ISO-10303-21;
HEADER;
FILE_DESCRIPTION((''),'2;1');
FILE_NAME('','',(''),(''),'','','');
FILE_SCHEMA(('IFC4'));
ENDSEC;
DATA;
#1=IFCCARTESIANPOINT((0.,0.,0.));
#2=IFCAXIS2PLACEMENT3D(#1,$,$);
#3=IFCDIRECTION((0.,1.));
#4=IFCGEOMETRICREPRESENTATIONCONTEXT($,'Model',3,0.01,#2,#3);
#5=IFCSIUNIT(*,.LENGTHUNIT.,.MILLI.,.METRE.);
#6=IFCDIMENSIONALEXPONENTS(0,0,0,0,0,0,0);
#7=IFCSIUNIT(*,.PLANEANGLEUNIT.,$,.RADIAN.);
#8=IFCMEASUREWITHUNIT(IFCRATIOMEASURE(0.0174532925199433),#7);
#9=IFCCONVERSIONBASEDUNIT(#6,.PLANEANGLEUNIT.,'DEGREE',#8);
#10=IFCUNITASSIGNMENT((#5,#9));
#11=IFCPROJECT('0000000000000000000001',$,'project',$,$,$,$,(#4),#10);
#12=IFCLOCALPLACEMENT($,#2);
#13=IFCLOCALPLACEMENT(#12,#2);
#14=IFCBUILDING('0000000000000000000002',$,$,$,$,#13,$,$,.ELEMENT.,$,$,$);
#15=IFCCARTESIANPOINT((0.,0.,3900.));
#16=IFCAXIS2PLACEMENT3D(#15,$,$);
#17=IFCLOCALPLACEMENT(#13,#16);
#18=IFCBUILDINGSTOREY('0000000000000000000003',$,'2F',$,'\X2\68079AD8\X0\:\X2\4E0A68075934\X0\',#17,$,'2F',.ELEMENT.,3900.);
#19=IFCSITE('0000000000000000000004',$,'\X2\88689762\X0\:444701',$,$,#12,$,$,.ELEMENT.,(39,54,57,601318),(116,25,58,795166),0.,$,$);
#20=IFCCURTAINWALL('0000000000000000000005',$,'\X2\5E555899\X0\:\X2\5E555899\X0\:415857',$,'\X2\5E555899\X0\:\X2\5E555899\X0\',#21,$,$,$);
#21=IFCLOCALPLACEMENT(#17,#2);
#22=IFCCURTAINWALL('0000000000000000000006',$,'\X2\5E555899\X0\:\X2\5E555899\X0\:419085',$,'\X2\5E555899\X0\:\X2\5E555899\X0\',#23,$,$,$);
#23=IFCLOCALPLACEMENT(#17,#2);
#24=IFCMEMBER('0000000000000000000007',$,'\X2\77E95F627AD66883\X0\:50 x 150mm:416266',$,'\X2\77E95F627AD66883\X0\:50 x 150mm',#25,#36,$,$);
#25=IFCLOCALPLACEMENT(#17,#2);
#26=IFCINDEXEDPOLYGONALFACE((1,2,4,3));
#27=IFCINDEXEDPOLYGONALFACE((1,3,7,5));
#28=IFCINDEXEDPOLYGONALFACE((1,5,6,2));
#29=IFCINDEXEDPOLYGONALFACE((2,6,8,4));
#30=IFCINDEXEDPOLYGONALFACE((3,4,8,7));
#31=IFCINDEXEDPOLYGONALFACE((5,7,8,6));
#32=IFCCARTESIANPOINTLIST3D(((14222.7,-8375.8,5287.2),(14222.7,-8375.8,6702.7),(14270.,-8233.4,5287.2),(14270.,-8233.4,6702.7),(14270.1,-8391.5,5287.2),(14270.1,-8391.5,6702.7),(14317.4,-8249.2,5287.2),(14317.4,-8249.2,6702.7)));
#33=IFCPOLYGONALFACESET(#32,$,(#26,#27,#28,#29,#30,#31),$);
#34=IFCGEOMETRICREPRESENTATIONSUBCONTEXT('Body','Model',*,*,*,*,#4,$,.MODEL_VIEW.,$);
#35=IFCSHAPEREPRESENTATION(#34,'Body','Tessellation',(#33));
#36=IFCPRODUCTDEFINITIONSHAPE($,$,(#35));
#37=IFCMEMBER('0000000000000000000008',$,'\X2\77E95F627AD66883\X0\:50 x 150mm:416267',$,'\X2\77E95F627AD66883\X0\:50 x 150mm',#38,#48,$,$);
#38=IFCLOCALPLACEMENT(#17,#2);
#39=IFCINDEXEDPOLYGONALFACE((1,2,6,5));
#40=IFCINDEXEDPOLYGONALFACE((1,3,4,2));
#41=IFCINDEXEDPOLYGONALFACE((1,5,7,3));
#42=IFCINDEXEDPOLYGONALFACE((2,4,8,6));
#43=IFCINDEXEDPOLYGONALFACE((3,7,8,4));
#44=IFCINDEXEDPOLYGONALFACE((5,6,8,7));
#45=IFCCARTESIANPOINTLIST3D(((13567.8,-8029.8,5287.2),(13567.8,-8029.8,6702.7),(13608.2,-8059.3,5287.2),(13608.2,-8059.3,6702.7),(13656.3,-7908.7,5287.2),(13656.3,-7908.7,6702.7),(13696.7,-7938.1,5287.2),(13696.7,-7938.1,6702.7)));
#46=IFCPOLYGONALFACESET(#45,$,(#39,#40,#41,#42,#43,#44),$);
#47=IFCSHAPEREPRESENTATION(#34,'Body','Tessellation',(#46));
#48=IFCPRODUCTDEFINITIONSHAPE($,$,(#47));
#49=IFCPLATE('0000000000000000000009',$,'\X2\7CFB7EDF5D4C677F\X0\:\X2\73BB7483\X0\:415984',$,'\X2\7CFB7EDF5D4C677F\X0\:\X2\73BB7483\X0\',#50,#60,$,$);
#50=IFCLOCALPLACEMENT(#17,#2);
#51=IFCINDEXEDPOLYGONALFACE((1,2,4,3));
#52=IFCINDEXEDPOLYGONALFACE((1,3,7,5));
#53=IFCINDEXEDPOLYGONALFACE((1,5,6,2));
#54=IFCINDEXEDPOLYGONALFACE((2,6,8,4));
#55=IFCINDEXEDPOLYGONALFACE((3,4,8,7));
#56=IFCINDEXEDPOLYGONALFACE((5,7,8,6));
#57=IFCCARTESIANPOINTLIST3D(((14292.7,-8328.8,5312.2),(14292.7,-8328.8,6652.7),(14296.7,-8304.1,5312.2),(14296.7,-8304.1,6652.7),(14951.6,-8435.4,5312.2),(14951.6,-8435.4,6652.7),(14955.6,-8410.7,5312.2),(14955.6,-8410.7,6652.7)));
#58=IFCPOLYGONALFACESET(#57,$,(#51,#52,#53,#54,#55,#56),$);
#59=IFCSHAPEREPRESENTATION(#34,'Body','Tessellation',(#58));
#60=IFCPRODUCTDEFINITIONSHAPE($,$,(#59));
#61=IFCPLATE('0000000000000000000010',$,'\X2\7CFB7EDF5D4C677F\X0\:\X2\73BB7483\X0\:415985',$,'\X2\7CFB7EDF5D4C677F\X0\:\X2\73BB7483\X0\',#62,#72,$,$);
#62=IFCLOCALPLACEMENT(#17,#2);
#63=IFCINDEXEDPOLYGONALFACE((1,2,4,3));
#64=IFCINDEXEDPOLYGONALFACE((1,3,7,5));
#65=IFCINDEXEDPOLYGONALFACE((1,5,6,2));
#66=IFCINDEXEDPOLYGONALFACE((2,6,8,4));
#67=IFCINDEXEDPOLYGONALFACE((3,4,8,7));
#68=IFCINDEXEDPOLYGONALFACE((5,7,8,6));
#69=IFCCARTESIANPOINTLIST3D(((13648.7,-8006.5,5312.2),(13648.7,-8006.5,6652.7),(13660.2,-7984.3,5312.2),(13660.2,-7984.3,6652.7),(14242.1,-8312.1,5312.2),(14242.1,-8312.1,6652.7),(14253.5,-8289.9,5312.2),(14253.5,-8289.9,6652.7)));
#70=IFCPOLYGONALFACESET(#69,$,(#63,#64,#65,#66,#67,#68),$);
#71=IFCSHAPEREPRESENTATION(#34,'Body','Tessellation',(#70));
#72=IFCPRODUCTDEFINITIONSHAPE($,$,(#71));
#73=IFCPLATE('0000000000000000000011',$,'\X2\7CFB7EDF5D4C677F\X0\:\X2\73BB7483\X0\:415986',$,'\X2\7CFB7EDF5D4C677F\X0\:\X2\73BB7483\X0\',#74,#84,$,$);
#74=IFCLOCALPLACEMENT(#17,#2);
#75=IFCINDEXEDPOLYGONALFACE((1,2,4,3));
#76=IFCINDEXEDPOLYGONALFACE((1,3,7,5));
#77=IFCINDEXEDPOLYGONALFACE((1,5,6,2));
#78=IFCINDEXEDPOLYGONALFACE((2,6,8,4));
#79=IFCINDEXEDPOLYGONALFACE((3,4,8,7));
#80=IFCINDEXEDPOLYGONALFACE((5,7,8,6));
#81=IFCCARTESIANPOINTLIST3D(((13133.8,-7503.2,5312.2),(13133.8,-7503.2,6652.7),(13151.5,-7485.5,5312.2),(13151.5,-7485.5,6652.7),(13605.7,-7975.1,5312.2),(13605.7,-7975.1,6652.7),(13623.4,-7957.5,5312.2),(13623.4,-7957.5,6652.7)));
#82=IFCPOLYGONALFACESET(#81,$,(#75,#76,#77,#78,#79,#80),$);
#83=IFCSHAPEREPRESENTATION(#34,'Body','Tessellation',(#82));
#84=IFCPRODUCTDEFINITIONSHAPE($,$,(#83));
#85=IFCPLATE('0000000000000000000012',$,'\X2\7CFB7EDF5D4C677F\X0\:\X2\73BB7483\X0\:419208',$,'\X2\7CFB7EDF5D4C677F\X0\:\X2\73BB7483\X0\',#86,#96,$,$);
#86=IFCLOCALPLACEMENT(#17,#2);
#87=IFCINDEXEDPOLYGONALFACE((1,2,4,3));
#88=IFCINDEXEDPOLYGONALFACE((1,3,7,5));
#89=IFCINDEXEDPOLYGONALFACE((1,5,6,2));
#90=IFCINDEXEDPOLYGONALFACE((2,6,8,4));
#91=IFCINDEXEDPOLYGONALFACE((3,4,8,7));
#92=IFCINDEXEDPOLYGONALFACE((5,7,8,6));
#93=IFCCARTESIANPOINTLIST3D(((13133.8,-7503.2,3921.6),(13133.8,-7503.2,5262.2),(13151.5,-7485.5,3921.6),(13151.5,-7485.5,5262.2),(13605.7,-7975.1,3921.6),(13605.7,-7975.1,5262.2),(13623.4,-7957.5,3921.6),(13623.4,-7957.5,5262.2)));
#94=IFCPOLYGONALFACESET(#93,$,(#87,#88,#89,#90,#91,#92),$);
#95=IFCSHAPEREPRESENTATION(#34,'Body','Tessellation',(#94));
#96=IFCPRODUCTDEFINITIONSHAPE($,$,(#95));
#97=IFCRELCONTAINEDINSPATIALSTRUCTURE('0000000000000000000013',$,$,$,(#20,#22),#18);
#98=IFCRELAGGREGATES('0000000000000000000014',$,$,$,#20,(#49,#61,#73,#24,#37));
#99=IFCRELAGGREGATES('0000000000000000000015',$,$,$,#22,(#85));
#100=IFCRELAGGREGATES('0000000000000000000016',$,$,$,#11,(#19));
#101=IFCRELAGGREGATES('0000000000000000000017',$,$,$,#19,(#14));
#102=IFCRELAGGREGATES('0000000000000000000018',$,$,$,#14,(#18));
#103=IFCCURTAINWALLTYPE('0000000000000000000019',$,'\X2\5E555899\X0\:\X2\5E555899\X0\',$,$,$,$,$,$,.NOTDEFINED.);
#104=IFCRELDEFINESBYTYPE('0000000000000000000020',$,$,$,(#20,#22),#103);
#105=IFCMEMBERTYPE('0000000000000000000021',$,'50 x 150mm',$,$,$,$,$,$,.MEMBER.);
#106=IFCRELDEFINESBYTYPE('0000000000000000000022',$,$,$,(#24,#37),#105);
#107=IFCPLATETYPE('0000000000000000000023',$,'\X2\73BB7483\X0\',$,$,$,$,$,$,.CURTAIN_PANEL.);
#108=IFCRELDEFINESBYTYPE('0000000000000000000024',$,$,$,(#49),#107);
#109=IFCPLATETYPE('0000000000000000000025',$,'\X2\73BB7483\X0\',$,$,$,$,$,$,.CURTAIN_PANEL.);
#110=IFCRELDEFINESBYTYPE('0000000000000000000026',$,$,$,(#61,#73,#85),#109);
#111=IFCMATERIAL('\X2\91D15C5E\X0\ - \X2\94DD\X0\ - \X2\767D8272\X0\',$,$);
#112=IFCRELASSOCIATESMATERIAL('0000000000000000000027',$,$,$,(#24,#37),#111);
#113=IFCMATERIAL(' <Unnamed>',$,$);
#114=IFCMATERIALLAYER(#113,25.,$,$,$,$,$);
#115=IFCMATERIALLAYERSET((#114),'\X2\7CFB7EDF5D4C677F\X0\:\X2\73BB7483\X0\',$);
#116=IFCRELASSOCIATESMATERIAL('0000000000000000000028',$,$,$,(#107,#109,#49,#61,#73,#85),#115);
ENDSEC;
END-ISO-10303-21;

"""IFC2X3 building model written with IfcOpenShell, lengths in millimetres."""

from ifc_helpers import new_model, entity, si_unit, converted_unit, direction, frame, frame_2d, origin, origin_2d_with_axis, place, context, subcontext, project, spatial, rectangle, extrude, source, transform, mapped, material, layer, layer_set, layer_usage, type_object, type_shapes, element, aggregate, save


model = new_model("IFC2X3")

# Units and contexts
model_context = context("Model", 3, precision=0.01, world=origin(), true_north=direction((0.0, 1.0)))
body_context = subcontext(model_context, "Body", "Model", "MODEL_VIEW")
ifc_project = project(units=[si_unit("LENGTHUNIT", "METRE", prefix="MILLI"), converted_unit("PLANEANGLEUNIT", "DEGREE", entity("IfcRatioMeasure", 0.0174532925199433), si_unit("PLANEANGLEUNIT", "RADIAN"), dimensions=[0, 0, 0, 0, 0, 0, 0])], contexts=[model_context])

# Site, building, storey
site_placement = place(None, origin())
site = spatial("IfcSite", under=ifc_project, at=site_placement, Name="表面:444701", CompositionType="ELEMENT", RefLatitude=(39, 54, 57, 601318), RefLongitude=(116, 25, 58, 795166), RefElevation=0.0)
building_placement = place(site_placement, origin())
building = spatial("IfcBuilding", under=site, at=building_placement, CompositionType="ELEMENT")
storey_placement = place(building_placement, frame((0.0, 0.0, 3900.0)))
storey = spatial("IfcBuildingStorey", under=building, at=storey_placement, Name="2F", ObjectType="标高:上标头", LongName="2F", CompositionType="ELEMENT", Elevation=3900.0)

# Curtain walls
curtain_wall_type = type_object("IfcCurtainWallType", Name="幕墙:幕墙", PredefinedType="NOTDEFINED")
curtain_wall_1_placement = place(storey_placement, frame((0.0, 0.0, -3900.0)))
curtain_wall_1 = element("IfcCurtainWall", 1, at=curtain_wall_1_placement, inside=storey, type_object=curtain_wall_type, Name="幕墙:幕墙:415857", ObjectType="幕墙:幕墙")
ifc_material_1 = material(Name="金属 - 铝 - 白色")
curtain_wall_2_placement = place(storey_placement, frame((0.0, 0.0, -3900.0)))
curtain_wall_2 = element("IfcCurtainWall", 2, at=curtain_wall_2_placement, inside=storey, type_object=curtain_wall_type, Name="幕墙:幕墙:419085", ObjectType="幕墙:幕墙")

# Members
member_type_1 = type_object("IfcMemberType", Name="50 x 150mm", PredefinedType="MEMBER")
shared_shape_1 = source(origin(), body_context, "Body", "SweptSolid", [
    extrude(rectangle(XDim=150.0, YDim=50.0, at=origin_2d_with_axis()), frame((0.0, 0.0, -1415.5), z_axis=(0.0, 0.0, 1.0), x_axis=(0.0, -1.0, 0.0)), (0.0, 0.0, 1.0), 1415.5),
])
type_shapes(member_type_1, [shared_shape_1])
member_1_placement = place(storey_placement, frame((14270.0, -8312.5, 5287.2), z_axis=(0.0, 0.0, -1.0), x_axis=(-0.949018, 0.315223, 0.0)))
member_1 = element("IfcMember", 3, at=member_1_placement, type_object=member_type_1, material=ifc_material_1, Name="矩形竖梃:50 x 150mm:416266", ObjectType="矩形竖梃:50 x 150mm", context=body_context, shape_type="MappedRepresentation", body=[
    mapped(shared_shape_1, transform((0.0, 0.0, 0.0), scale=1.0)),
])
member_2_placement = place(storey_placement, frame((13632.2, -7984.0, 5287.2), z_axis=(0.0, 0.0, -1.0), x_axis=(-0.807735, 0.589546, 0.0)))
member_2 = element("IfcMember", 4, at=member_2_placement, type_object=member_type_1, material=ifc_material_1, Name="矩形竖梃:50 x 150mm:416267", ObjectType="矩形竖梃:50 x 150mm", context=body_context, shape_type="MappedRepresentation", body=[
    mapped(shared_shape_1, transform((0.0, 0.0, 0.0), scale=1.0)),
])

# Plates
ifc_material_2 = material(Name=" <Unnamed>")
ifc_layer = layer(ifc_material_2, 25.0)
ifc_layer_set = layer_set([ifc_layer], Name="系统嵌板:玻璃")
ifc_layer_usage_1 = layer_usage(ifc_layer_set, "AXIS3", "POSITIVE", 0.0)
plate_type_1 = type_object("IfcPlateType", Name="玻璃", PredefinedType="CURTAIN_PANEL", material=ifc_layer_set)
shared_shape_2 = source(origin(), body_context, "Body", "SweptSolid", [
    extrude(rectangle(XDim=25.0, YDim=667.4, at=frame_2d((0.0, 0.0), x_axis=(1.0, 0.0))), frame((0.0, 0.0, 0.0), z_axis=(0.0, 0.0, 1.0), x_axis=(0.0, 1.0, 0.0)), (0.0, 0.0, 1.0), 1340.5),
])
type_shapes(plate_type_1, [shared_shape_2])
plate_1_placement = place(curtain_wall_1_placement, frame((14624.2, -8369.7, 9212.2), z_axis=(0.0, 0.0, 1.0), x_axis=(-0.987172, 0.15966, 0.0)))
plate_1 = element("IfcPlate", 5, at=plate_1_placement, type_object=plate_type_1, material=ifc_layer_usage_1, Name="系统嵌板:玻璃:415984", ObjectType="系统嵌板:玻璃", context=body_context, shape_type="MappedRepresentation", body=[
    mapped(shared_shape_2, transform((0.0, 0.0, 0.0), scale=1.0)),
])
ifc_layer_usage_2 = layer_usage(ifc_layer_set, "AXIS3", "POSITIVE", 0.0)
plate_type_2 = type_object("IfcPlateType", Name="玻璃", PredefinedType="CURTAIN_PANEL", material=ifc_layer_set)
shared_shape_3 = source(origin(), body_context, "Body", "SweptSolid", [
    extrude(rectangle(XDim=25.0, YDim=667.4, at=frame_2d((0.0, 0.0), x_axis=(1.0, 0.0))), frame((0.0, 0.0, 0.0), z_axis=(0.0, 0.0, 1.0), x_axis=(0.0, 1.0, 0.0)), (0.0, 0.0, 1.0), 1340.5),
])
type_shapes(plate_type_2, [shared_shape_3])
plate_2_placement = place(curtain_wall_1_placement, frame((13951.1, -8148.2, 9212.2), z_axis=(0.0, 0.0, 1.0), x_axis=(-0.889021, 0.457867, 0.0)))
plate_2 = element("IfcPlate", 6, at=plate_2_placement, type_object=plate_type_2, material=ifc_layer_usage_2, Name="系统嵌板:玻璃:415985", ObjectType="系统嵌板:玻璃", context=body_context, shape_type="MappedRepresentation", body=[
    mapped(shared_shape_3, transform((0.0, 0.0, 0.0), scale=1.0)),
])
ifc_layer_usage_3 = layer_usage(ifc_layer_set, "AXIS3", "POSITIVE", 0.0)
plate_3_placement = place(curtain_wall_1_placement, frame((13378.6, -7730.3, 9212.2), z_axis=(0.0, 0.0, 1.0), x_axis=(-0.707107, 0.707107, 0.0)))
plate_3 = element("IfcPlate", 7, at=plate_3_placement, type_object=plate_type_2, material=ifc_layer_usage_3, Name="系统嵌板:玻璃:415986", ObjectType="系统嵌板:玻璃", context=body_context, shape_type="MappedRepresentation", body=[
    mapped(shared_shape_3, transform((0.0, 0.0, 0.0), scale=1.0)),
])
aggregate(curtain_wall_1, [plate_1, plate_2, plate_3, member_1, member_2])
ifc_layer_usage_4 = layer_usage(ifc_layer_set, "AXIS3", "POSITIVE", 0.0)
plate_4_placement = place(curtain_wall_2_placement, frame((13378.6, -7730.3, 7821.6), z_axis=(0.0, 0.0, 1.0), x_axis=(-0.707107, 0.707107, 0.0)))
plate_4 = element("IfcPlate", 8, at=plate_4_placement, type_object=plate_type_2, material=ifc_layer_usage_4, Name="系统嵌板:玻璃:419208", ObjectType="系统嵌板:玻璃", context=body_context, shape_type="MappedRepresentation", body=[
    mapped(shared_shape_3, transform((0.0, 0.0, 0.0), scale=1.0)),
])
aggregate(curtain_wall_2, [plate_4])

save(model, "model.ifc")
